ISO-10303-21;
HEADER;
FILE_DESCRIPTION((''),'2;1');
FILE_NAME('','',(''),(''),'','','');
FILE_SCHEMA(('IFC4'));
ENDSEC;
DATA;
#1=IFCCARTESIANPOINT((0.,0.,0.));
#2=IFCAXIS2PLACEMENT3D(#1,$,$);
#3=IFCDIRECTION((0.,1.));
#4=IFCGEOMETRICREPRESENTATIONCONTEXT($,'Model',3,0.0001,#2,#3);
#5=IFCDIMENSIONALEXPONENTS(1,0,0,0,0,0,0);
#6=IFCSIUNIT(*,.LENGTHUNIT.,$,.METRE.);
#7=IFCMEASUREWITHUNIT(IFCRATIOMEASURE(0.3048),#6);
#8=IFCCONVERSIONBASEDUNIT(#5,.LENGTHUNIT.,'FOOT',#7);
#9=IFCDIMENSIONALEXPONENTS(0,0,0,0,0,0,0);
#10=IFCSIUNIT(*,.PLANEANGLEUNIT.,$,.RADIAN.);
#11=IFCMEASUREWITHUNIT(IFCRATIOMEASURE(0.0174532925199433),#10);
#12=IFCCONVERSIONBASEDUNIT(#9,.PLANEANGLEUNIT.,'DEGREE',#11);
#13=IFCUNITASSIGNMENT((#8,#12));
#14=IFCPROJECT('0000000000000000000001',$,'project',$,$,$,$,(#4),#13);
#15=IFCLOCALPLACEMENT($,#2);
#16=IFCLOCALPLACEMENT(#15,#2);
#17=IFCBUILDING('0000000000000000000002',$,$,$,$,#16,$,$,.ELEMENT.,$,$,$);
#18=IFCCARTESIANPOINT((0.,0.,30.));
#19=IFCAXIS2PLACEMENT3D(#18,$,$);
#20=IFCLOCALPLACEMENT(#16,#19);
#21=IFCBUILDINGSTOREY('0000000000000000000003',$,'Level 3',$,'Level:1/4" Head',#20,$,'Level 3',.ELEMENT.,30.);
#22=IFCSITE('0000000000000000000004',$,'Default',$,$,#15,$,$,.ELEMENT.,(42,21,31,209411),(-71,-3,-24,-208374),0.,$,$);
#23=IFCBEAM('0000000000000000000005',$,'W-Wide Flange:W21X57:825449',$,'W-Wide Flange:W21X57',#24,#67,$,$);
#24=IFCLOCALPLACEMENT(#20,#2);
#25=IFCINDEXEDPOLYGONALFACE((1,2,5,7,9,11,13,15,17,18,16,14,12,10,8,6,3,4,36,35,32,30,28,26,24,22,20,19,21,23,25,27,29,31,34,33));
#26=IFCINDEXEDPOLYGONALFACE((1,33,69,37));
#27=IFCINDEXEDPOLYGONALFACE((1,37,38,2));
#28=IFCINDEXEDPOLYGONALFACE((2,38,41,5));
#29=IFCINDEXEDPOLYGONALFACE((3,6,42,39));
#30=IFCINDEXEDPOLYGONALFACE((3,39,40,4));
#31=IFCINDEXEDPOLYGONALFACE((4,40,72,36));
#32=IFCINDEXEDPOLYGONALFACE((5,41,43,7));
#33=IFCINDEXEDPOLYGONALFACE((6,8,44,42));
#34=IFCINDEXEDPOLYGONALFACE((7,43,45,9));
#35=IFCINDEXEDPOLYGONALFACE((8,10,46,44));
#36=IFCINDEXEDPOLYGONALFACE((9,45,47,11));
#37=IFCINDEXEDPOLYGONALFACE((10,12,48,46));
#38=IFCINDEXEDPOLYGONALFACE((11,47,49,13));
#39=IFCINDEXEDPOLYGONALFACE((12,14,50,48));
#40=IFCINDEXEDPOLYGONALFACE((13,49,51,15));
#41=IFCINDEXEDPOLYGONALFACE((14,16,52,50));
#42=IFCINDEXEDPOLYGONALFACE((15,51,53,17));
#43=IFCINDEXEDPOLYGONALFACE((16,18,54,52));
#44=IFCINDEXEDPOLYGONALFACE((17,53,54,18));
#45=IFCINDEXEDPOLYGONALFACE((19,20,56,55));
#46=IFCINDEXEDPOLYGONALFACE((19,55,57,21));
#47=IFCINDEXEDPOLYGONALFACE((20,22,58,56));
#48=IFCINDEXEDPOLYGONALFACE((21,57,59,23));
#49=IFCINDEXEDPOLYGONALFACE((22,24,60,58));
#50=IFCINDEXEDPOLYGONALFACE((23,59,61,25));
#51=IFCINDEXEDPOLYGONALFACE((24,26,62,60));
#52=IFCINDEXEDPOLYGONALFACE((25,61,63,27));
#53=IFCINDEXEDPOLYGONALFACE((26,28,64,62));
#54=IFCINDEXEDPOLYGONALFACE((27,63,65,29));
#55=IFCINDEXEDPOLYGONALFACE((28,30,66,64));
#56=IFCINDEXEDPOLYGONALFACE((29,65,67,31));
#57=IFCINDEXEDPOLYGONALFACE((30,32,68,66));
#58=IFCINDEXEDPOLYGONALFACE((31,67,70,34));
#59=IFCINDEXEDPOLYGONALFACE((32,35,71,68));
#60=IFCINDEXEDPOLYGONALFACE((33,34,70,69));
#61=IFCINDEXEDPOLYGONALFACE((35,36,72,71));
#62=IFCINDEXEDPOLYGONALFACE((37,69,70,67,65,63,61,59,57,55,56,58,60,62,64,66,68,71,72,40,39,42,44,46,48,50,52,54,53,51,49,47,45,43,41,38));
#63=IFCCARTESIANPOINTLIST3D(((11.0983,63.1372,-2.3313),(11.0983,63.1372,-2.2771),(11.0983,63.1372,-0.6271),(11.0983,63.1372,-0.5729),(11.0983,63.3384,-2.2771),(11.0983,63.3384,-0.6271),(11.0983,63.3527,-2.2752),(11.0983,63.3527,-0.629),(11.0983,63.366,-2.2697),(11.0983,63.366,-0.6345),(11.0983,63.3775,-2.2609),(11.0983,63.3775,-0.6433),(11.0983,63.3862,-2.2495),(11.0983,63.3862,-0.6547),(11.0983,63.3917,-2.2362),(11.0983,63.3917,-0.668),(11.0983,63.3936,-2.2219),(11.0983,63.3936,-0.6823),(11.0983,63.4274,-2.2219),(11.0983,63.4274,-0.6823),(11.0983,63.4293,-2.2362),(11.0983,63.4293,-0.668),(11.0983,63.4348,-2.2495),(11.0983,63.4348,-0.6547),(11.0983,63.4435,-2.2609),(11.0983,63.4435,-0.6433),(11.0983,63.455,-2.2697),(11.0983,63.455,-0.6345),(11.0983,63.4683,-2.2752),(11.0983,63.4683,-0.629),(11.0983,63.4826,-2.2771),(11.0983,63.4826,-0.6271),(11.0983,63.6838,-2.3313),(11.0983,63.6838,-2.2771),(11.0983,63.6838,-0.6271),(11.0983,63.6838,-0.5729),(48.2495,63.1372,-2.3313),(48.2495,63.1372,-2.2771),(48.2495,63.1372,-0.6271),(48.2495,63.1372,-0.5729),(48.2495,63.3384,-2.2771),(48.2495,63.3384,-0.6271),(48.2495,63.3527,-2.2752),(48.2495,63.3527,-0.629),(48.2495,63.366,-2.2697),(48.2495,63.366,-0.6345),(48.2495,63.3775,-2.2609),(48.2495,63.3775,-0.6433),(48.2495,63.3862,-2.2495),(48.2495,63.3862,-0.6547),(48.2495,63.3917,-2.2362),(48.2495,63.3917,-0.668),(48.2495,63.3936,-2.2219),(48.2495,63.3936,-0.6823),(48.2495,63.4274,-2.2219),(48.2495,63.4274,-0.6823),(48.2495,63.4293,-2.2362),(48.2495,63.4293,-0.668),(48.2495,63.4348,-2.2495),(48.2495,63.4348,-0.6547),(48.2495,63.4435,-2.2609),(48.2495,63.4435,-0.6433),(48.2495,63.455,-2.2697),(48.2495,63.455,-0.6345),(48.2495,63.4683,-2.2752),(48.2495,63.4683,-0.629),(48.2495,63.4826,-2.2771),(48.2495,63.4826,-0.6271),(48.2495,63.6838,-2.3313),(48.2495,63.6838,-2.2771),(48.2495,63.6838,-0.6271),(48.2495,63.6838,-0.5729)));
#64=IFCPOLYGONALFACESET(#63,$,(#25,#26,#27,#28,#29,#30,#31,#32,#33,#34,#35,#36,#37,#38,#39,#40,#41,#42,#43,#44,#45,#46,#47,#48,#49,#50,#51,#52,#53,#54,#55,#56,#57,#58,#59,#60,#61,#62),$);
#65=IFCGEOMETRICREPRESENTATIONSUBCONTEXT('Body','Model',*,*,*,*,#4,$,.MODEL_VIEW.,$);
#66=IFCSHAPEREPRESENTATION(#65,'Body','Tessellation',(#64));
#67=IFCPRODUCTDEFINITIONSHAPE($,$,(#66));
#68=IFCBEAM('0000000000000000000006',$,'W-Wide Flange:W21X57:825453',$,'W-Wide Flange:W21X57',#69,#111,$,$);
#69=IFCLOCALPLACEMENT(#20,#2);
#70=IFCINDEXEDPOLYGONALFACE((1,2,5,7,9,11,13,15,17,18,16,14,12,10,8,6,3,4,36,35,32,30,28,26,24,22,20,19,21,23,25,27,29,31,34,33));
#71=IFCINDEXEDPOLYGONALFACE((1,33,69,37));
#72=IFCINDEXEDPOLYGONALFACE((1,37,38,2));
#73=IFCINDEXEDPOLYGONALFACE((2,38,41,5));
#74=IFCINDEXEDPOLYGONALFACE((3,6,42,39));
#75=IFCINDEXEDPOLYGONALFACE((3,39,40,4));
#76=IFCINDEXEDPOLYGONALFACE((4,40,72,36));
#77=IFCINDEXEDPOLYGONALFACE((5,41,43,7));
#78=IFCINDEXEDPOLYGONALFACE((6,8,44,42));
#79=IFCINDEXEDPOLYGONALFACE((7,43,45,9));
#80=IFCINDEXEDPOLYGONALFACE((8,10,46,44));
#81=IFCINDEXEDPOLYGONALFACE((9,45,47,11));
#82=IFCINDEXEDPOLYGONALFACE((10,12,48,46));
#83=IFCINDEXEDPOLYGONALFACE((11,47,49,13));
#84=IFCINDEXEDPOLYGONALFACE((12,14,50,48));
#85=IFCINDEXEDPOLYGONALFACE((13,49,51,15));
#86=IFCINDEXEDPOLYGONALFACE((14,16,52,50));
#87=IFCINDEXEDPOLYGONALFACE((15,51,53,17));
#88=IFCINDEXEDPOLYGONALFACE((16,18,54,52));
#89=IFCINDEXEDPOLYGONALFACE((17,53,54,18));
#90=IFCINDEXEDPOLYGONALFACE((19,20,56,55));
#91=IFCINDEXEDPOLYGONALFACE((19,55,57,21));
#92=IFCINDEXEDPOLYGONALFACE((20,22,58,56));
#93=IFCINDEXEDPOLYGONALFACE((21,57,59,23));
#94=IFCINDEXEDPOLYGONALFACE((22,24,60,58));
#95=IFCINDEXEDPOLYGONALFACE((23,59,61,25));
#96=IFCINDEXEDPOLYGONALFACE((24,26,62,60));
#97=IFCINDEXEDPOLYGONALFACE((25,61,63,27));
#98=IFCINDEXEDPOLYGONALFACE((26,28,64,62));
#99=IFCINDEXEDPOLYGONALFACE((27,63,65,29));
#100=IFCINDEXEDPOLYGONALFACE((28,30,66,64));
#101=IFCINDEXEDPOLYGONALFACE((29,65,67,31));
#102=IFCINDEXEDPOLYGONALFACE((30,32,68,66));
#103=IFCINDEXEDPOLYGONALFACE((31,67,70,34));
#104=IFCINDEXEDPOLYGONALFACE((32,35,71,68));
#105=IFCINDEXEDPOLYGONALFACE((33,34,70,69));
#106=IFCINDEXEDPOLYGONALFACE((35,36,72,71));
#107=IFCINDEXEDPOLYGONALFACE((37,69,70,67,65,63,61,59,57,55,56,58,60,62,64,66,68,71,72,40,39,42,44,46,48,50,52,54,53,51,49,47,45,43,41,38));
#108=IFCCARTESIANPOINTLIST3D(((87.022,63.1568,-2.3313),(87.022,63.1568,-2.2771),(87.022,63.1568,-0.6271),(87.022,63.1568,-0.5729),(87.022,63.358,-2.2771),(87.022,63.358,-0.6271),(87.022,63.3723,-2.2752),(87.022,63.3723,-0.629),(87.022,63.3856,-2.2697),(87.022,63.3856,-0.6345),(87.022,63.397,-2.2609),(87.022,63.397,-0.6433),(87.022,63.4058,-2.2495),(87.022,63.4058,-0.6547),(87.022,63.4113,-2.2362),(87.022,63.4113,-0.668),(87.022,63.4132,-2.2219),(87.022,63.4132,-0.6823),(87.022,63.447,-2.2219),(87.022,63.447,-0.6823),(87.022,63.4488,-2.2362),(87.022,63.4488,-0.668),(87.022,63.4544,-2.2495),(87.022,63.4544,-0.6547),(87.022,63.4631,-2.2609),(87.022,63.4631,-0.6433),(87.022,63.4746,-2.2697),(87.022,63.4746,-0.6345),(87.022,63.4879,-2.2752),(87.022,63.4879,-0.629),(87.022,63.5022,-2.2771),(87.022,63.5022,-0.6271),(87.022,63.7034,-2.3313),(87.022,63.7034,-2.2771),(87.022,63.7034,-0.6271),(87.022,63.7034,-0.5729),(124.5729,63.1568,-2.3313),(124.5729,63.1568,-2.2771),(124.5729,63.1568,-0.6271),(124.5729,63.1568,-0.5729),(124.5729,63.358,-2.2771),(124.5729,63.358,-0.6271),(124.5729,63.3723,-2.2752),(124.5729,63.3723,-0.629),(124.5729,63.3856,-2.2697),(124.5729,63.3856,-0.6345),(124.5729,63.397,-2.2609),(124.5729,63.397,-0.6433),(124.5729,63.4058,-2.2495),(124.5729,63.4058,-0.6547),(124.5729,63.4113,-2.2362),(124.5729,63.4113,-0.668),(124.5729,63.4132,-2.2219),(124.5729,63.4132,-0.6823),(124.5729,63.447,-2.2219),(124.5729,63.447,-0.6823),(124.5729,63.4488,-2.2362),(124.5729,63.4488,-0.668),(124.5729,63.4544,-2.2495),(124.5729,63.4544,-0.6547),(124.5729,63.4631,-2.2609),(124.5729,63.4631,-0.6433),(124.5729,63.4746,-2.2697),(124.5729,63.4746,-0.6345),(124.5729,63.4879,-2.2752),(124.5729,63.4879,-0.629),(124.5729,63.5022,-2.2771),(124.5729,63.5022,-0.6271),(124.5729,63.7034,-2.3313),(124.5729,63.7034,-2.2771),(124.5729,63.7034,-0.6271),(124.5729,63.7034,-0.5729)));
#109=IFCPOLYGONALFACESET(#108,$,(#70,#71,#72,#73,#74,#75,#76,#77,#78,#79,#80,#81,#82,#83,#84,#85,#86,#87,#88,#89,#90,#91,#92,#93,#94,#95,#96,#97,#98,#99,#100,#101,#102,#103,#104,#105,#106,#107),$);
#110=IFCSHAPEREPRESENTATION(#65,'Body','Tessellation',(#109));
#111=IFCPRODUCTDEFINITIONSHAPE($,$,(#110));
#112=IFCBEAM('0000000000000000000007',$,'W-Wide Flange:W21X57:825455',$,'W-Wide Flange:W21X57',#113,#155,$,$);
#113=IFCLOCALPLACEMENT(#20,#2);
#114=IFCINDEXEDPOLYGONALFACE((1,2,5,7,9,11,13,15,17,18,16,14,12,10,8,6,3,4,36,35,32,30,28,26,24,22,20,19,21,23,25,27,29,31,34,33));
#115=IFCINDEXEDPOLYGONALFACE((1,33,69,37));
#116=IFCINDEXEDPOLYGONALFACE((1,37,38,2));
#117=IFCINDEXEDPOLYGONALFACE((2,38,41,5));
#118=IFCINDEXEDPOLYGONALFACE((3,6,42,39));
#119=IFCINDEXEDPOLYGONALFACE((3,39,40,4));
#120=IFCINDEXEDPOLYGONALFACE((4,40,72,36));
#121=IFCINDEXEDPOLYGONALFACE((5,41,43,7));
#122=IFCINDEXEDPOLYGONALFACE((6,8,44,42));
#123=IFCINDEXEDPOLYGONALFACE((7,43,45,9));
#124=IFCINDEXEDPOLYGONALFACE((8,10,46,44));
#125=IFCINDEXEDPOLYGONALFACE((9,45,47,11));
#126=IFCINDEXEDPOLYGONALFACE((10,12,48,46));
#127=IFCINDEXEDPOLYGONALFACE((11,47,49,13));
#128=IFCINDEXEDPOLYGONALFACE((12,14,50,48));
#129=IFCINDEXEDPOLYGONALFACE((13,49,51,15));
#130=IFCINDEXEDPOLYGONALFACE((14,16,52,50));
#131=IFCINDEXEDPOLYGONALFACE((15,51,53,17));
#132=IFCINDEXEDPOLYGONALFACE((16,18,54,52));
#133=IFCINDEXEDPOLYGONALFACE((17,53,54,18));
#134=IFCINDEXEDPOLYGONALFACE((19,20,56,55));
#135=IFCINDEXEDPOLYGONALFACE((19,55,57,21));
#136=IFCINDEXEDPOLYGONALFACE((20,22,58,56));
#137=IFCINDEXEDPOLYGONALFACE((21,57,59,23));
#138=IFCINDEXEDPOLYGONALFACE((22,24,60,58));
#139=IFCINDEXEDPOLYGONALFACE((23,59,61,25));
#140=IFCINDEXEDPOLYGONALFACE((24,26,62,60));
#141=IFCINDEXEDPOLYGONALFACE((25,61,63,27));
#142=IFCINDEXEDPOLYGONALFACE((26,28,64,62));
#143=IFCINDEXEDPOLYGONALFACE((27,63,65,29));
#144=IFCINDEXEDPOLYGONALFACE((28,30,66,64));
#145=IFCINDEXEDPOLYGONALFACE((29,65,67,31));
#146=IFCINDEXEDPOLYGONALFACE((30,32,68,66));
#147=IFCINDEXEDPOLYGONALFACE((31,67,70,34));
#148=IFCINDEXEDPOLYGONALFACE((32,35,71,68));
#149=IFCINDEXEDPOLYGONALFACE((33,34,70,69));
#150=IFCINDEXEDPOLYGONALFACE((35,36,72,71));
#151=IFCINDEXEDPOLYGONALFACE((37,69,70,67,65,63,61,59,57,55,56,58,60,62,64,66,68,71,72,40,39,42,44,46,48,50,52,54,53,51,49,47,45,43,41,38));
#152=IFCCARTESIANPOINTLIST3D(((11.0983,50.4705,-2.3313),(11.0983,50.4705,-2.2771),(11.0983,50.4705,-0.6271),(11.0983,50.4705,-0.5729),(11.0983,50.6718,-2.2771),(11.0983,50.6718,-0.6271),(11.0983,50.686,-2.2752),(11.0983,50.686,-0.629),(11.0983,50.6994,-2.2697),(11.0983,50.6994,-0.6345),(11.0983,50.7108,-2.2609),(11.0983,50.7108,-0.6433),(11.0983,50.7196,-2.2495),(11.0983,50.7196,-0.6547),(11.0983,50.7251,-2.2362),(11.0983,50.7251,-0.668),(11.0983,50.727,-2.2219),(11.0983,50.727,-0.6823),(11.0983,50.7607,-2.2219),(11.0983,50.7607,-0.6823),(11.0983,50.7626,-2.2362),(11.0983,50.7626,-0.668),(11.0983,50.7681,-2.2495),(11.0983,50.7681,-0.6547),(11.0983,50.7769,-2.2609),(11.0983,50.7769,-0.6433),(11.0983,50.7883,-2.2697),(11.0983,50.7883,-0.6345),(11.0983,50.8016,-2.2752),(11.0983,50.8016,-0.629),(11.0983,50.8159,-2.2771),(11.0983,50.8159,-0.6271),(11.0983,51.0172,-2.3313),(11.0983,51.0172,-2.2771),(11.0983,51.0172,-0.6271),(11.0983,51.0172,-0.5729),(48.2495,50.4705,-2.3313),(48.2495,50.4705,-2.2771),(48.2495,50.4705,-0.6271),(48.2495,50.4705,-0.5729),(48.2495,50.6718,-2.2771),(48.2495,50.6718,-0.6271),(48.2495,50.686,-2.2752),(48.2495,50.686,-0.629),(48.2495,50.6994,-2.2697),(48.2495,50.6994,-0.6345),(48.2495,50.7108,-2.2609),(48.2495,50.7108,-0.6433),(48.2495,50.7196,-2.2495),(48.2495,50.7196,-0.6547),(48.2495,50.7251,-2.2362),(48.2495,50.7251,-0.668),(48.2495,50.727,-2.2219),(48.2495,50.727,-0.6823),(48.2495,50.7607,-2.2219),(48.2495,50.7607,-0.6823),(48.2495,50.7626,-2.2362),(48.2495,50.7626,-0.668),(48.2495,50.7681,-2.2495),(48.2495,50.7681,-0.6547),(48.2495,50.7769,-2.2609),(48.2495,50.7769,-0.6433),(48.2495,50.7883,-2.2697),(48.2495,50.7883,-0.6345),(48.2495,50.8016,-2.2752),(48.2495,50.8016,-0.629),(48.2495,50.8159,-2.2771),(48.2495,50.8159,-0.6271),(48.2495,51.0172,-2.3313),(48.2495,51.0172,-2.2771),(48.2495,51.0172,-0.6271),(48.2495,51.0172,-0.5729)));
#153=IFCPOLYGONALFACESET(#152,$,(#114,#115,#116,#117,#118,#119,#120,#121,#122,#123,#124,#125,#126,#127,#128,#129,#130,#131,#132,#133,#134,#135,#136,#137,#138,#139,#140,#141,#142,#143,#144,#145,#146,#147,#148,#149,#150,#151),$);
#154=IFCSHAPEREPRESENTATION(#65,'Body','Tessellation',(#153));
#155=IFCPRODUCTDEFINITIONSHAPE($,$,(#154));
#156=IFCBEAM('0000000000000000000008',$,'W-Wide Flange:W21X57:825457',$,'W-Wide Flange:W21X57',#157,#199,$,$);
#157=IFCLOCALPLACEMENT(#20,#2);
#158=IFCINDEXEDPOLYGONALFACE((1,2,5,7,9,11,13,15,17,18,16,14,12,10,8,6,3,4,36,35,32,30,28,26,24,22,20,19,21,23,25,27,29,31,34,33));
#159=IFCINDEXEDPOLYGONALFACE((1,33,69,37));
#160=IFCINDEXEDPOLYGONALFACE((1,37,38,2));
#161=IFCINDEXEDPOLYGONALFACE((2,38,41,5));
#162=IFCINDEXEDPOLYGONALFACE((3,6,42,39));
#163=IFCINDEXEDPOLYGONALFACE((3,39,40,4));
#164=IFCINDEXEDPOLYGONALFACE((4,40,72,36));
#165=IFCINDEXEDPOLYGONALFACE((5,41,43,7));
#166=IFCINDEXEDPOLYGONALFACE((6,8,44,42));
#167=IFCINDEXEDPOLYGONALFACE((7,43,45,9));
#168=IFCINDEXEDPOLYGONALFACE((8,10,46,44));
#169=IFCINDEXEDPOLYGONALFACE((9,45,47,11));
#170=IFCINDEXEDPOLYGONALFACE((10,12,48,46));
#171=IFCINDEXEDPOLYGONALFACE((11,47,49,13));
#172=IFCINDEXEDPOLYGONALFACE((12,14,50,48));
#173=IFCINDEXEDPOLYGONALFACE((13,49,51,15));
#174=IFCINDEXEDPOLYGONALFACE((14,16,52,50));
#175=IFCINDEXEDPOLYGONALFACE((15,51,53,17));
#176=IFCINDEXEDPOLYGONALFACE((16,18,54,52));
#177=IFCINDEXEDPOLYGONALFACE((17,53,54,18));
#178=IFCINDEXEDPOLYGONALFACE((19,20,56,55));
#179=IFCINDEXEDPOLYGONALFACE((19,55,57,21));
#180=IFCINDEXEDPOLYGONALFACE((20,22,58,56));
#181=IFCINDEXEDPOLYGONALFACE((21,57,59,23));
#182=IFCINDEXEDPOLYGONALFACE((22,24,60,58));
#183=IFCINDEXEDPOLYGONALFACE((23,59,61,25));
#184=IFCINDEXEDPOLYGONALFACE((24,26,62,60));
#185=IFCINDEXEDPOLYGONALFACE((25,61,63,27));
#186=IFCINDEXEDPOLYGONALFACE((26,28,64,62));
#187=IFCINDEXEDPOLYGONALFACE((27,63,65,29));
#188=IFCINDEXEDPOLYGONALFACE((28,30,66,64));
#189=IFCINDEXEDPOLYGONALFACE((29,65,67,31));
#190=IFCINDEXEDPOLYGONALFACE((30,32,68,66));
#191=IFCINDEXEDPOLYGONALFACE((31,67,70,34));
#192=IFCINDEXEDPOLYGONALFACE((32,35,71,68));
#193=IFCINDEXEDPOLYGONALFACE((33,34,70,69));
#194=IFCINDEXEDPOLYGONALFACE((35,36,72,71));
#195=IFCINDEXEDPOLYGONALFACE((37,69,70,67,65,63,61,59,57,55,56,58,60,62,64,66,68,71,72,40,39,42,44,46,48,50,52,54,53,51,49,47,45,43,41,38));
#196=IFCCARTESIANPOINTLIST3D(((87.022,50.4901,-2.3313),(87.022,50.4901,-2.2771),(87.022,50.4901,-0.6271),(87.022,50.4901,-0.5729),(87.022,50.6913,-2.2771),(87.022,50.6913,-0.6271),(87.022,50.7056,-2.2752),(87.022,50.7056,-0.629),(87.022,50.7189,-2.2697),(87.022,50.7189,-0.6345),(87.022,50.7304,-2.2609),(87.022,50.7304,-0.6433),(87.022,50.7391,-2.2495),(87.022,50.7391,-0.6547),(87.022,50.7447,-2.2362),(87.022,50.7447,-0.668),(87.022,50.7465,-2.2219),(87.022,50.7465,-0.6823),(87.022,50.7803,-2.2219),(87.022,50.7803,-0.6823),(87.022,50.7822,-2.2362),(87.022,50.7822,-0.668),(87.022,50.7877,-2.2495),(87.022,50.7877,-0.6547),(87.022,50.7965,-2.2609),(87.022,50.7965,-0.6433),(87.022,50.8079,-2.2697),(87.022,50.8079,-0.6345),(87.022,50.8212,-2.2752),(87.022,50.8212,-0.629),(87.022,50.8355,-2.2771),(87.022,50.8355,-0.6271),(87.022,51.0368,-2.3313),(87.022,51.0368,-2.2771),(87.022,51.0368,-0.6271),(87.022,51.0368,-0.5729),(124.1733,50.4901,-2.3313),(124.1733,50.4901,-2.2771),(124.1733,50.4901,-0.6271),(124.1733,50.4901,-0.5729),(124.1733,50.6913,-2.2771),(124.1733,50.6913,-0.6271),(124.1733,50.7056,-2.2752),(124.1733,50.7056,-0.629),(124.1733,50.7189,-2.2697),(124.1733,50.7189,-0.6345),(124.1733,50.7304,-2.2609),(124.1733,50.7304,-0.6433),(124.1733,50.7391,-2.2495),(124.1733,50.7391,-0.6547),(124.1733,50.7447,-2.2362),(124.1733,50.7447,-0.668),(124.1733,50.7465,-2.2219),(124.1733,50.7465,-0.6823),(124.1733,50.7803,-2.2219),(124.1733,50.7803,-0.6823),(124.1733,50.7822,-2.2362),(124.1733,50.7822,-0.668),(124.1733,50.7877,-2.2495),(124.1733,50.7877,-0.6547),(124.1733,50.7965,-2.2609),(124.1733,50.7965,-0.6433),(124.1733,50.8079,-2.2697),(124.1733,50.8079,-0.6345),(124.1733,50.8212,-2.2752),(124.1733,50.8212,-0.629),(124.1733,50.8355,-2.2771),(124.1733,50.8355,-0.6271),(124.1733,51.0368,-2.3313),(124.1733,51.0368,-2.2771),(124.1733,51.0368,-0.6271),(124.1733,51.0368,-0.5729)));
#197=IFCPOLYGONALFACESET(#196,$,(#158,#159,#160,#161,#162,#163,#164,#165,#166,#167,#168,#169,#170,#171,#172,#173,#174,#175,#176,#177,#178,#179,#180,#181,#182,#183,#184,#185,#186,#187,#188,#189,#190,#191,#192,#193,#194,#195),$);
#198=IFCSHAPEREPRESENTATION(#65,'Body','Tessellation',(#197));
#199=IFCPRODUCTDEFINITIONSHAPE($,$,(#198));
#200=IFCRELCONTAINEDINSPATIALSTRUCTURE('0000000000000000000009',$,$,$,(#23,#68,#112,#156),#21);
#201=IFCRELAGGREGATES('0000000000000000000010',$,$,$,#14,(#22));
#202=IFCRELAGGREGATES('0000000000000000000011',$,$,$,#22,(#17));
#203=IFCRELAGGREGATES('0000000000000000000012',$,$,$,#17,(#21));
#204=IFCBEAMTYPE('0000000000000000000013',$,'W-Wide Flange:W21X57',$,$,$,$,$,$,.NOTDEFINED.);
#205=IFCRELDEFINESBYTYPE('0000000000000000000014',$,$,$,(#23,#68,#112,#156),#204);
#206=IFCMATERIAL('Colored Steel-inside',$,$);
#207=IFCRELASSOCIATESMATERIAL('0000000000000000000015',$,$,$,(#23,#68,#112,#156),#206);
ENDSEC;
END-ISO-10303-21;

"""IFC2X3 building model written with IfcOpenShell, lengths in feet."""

from ifc_helpers import new_model, entity, si_unit, converted_unit, direction, frame, frame_2d, origin, place, context, subcontext, project, spatial, i_section, extrude, material, type_object, element, save


model = new_model("IFC2X3")

# Units and contexts
model_context = context("Model", 3, precision=0.0001, world=origin(), true_north=direction((0.0, 1.0)))
body_context = subcontext(model_context, "Body", "Model", "MODEL_VIEW")
ifc_project = project(units=[converted_unit("LENGTHUNIT", "FOOT", entity("IfcRatioMeasure", 0.3048), si_unit("LENGTHUNIT", "METRE"), dimensions=[1, 0, 0, 0, 0, 0, 0]), converted_unit("PLANEANGLEUNIT", "DEGREE", entity("IfcRatioMeasure", 0.0174532925199433), si_unit("PLANEANGLEUNIT", "RADIAN"), dimensions=[0, 0, 0, 0, 0, 0, 0])], contexts=[model_context])

# Site, building, storey
site_placement = place(None, origin())
site = spatial("IfcSite", under=ifc_project, at=site_placement, Name="Default", CompositionType="ELEMENT", RefLatitude=(42, 21, 31, 209411), RefLongitude=(-71, -3, -24, -208374), RefElevation=0.0)
building_placement = place(site_placement, origin())
building = spatial("IfcBuilding", under=site, at=building_placement, CompositionType="ELEMENT")
storey_placement = place(building_placement, frame((0.0, 0.0, 30.0)))
storey = spatial("IfcBuildingStorey", under=building, at=storey_placement, Name="Level 3", ObjectType="Level:1/4\" Head", LongName="Level 3", CompositionType="ELEMENT", Elevation=30.0)

# Beams
ifc_material_1 = material(Name="Colored Steel-inside")
beam_type_1 = type_object("IfcBeamType", Name="W-Wide Flange:W21X57", PredefinedType="NOTDEFINED")
beam_1_placement = place(storey_placement, frame((10.6358, 63.4105, 0.0)))
element("IfcBeam", 1, at=beam_1_placement, inside=storey, type_object=beam_type_1, material=ifc_material_1, Name="W-Wide Flange:W21X57:825449", ObjectType="W-Wide Flange:W21X57", context=body_context, shape_type="SweptSolid", body=[
    extrude(i_section(OverallWidth=0.5467, OverallDepth=1.7583, WebThickness=0.0337, FlangeThickness=0.0542, FilletRadius=0.0552, at=frame_2d((0.0, 0.0), x_axis=(0.0, 1.0))), frame((0.4625, 0.0, -1.4521), z_axis=(1.0, 0.0, 0.0), x_axis=(0.0, 0.0, -1.0)), (0.0, 0.0, 1.0), 37.1513),
])
beam_2_placement = place(storey_placement, frame((86.6358, 63.4301, 0.0)))
element("IfcBeam", 2, at=beam_2_placement, inside=storey, type_object=beam_type_1, material=ifc_material_1, Name="W-Wide Flange:W21X57:825453", ObjectType="W-Wide Flange:W21X57", context=body_context, shape_type="SweptSolid", body=[
    extrude(i_section(OverallWidth=0.5467, OverallDepth=1.7583, WebThickness=0.0337, FlangeThickness=0.0542, FilletRadius=0.0552, at=frame_2d((0.0, 0.0), x_axis=(0.0, 1.0))), frame((0.3863, 0.0, -1.4521), z_axis=(1.0, 0.0, 0.0), x_axis=(0.0, 0.0, -1.0)), (0.0, 0.0, 1.0), 37.5508),
])
beam_3_placement = place(storey_placement, frame((10.6358, 50.7438, 0.0)))
element("IfcBeam", 3, at=beam_3_placement, inside=storey, type_object=beam_type_1, material=ifc_material_1, Name="W-Wide Flange:W21X57:825455", ObjectType="W-Wide Flange:W21X57", context=body_context, shape_type="SweptSolid", body=[
    extrude(i_section(OverallWidth=0.5467, OverallDepth=1.7583, WebThickness=0.0337, FlangeThickness=0.0542, FilletRadius=0.0552, at=frame_2d((0.0, 0.0), x_axis=(0.0, 1.0))), frame((0.4625, 0.0, -1.4521), z_axis=(1.0, 0.0, 0.0), x_axis=(0.0, 0.0, -1.0)), (0.0, 0.0, 1.0), 37.1513),
])
beam_4_placement = place(storey_placement, frame((86.6358, 50.7634, 0.0)))
element("IfcBeam", 4, at=beam_4_placement, inside=storey, type_object=beam_type_1, material=ifc_material_1, Name="W-Wide Flange:W21X57:825457", ObjectType="W-Wide Flange:W21X57", context=body_context, shape_type="SweptSolid", body=[
    extrude(i_section(OverallWidth=0.5467, OverallDepth=1.7583, WebThickness=0.0337, FlangeThickness=0.0542, FilletRadius=0.0552, at=frame_2d((0.0, 0.0), x_axis=(0.0, 1.0))), frame((0.3862, 0.0, -1.4521), z_axis=(1.0, 0.0, 0.0), x_axis=(0.0, 0.0, -1.0)), (0.0, 0.0, 1.0), 37.1512),
])

save(model, "model.ifc")
